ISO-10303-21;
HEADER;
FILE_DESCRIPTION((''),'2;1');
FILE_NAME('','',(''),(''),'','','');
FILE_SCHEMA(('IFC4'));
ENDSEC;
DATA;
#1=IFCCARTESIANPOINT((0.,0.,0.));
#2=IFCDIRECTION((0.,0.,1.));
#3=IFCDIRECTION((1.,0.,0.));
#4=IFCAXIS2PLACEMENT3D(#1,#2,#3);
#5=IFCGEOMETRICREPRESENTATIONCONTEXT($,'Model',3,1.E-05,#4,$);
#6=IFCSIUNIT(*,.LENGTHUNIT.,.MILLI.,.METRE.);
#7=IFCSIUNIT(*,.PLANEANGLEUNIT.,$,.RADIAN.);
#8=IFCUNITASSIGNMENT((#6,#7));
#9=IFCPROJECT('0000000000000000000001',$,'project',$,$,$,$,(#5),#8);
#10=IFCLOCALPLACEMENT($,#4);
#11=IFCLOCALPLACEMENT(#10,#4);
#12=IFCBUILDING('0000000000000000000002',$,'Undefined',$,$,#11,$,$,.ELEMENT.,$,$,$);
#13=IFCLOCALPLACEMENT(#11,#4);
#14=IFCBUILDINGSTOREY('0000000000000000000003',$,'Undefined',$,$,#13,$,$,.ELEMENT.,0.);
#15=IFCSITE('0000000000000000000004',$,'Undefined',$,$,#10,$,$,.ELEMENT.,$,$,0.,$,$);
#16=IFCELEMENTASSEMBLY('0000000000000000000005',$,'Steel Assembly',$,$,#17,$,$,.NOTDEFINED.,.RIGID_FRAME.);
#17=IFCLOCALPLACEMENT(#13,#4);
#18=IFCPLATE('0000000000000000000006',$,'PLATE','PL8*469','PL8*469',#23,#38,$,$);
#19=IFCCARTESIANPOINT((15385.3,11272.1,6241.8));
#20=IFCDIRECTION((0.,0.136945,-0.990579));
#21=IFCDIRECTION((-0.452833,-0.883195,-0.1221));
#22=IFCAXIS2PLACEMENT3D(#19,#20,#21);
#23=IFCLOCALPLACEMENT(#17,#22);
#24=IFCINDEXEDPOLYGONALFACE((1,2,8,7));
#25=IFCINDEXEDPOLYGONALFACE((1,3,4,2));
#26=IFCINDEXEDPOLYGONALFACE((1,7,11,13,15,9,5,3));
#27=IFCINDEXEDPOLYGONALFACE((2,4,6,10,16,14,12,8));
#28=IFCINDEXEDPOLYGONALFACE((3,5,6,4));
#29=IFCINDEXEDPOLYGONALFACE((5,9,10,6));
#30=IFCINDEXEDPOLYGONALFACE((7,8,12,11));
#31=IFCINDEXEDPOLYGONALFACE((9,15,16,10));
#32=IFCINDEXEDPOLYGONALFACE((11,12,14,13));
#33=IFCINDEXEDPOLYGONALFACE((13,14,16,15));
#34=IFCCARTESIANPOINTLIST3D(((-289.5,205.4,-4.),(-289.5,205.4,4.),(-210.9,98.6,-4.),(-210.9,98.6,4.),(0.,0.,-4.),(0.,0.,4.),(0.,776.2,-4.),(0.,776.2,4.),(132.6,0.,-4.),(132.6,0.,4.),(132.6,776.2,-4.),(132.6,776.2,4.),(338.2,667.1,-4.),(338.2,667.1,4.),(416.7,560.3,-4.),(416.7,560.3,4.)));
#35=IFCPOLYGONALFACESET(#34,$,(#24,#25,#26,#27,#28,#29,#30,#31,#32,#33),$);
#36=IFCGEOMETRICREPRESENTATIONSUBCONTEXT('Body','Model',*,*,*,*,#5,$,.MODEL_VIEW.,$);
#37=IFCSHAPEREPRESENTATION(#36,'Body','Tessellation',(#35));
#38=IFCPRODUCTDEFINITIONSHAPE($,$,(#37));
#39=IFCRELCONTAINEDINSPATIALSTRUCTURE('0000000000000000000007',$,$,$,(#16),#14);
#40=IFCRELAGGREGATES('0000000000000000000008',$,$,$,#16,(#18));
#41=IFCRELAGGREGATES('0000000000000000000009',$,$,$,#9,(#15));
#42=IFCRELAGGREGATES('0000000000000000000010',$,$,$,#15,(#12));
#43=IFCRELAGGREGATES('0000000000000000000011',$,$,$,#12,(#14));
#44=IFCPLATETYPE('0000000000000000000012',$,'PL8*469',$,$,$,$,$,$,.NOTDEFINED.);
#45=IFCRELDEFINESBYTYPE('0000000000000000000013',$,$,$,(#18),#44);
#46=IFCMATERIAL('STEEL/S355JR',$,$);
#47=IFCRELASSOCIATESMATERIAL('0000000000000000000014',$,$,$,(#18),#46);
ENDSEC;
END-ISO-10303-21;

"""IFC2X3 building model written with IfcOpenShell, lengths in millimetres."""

from ifc_helpers import new_model, si_unit, frame, origin_with_axes, place, context, subcontext, project, spatial, polyline, outline, extrude, material, type_object, element, aggregate, save


model = new_model("IFC2X3")

# Units and contexts
model_context = context("Model", 3, precision=1e-05, world=origin_with_axes())
body_context = subcontext(model_context, "Body", "Model", "MODEL_VIEW")
ifc_project = project(units=[si_unit("LENGTHUNIT", "METRE", prefix="MILLI"), si_unit("PLANEANGLEUNIT", "RADIAN")], contexts=[model_context])

# Site, building, storey
site_placement = place(None, origin_with_axes())
site = spatial("IfcSite", under=ifc_project, at=site_placement, Name="Undefined", CompositionType="ELEMENT", RefElevation=0.0)
building_placement = place(site_placement, origin_with_axes())
building = spatial("IfcBuilding", under=site, at=building_placement, Name="Undefined", CompositionType="ELEMENT")
storey_placement = place(building_placement, origin_with_axes())
storey = spatial("IfcBuildingStorey", under=building, at=storey_placement, Name="Undefined", CompositionType="ELEMENT", Elevation=0.0)

# Shared definitions
ifc_material_1 = material(Name="STEEL/S355JR")

# Element assembly, plate
assembly_1_placement = place(storey_placement, origin_with_axes())
assembly_1 = element("IfcElementAssembly", 1, at=assembly_1_placement, inside=storey, Name="Steel Assembly", AssemblyPlace="NOTDEFINED", PredefinedType="RIGID_FRAME")
plate_type_1 = type_object("IfcPlateType", Name="PL8*469", PredefinedType="NOTDEFINED")
plate_1_placement = place(assembly_1_placement, frame((15385.3, 11272.1, 6241.8), z_axis=(0.0, 0.136945, -0.990579), x_axis=(-0.452833, -0.883195, -0.1221)))
plate_1 = element("IfcPlate", 2, at=plate_1_placement, type_object=plate_type_1, material=ifc_material_1, Name="PLATE", Description="PL8*469", ObjectType="PL8*469", context=body_context, shape_type="SweptSolid", body=[
    extrude(outline(polyline([(0.0, 0.0), (132.6, 0.0), (416.7, 560.3), (338.2, 667.1), (132.6, 776.2), (0.0, 776.2), (-289.5, 205.4), (-210.9, 98.6), (0.0, 0.0)])), frame((0.0, 0.0, -4.0), z_axis=(0.0, 0.0, 1.0), x_axis=(1.0, 0.0, 0.0)), (0.0, 0.0, 1.0), 8.0),
])

aggregate(assembly_1, [plate_1])

save(model, "model.ifc")
